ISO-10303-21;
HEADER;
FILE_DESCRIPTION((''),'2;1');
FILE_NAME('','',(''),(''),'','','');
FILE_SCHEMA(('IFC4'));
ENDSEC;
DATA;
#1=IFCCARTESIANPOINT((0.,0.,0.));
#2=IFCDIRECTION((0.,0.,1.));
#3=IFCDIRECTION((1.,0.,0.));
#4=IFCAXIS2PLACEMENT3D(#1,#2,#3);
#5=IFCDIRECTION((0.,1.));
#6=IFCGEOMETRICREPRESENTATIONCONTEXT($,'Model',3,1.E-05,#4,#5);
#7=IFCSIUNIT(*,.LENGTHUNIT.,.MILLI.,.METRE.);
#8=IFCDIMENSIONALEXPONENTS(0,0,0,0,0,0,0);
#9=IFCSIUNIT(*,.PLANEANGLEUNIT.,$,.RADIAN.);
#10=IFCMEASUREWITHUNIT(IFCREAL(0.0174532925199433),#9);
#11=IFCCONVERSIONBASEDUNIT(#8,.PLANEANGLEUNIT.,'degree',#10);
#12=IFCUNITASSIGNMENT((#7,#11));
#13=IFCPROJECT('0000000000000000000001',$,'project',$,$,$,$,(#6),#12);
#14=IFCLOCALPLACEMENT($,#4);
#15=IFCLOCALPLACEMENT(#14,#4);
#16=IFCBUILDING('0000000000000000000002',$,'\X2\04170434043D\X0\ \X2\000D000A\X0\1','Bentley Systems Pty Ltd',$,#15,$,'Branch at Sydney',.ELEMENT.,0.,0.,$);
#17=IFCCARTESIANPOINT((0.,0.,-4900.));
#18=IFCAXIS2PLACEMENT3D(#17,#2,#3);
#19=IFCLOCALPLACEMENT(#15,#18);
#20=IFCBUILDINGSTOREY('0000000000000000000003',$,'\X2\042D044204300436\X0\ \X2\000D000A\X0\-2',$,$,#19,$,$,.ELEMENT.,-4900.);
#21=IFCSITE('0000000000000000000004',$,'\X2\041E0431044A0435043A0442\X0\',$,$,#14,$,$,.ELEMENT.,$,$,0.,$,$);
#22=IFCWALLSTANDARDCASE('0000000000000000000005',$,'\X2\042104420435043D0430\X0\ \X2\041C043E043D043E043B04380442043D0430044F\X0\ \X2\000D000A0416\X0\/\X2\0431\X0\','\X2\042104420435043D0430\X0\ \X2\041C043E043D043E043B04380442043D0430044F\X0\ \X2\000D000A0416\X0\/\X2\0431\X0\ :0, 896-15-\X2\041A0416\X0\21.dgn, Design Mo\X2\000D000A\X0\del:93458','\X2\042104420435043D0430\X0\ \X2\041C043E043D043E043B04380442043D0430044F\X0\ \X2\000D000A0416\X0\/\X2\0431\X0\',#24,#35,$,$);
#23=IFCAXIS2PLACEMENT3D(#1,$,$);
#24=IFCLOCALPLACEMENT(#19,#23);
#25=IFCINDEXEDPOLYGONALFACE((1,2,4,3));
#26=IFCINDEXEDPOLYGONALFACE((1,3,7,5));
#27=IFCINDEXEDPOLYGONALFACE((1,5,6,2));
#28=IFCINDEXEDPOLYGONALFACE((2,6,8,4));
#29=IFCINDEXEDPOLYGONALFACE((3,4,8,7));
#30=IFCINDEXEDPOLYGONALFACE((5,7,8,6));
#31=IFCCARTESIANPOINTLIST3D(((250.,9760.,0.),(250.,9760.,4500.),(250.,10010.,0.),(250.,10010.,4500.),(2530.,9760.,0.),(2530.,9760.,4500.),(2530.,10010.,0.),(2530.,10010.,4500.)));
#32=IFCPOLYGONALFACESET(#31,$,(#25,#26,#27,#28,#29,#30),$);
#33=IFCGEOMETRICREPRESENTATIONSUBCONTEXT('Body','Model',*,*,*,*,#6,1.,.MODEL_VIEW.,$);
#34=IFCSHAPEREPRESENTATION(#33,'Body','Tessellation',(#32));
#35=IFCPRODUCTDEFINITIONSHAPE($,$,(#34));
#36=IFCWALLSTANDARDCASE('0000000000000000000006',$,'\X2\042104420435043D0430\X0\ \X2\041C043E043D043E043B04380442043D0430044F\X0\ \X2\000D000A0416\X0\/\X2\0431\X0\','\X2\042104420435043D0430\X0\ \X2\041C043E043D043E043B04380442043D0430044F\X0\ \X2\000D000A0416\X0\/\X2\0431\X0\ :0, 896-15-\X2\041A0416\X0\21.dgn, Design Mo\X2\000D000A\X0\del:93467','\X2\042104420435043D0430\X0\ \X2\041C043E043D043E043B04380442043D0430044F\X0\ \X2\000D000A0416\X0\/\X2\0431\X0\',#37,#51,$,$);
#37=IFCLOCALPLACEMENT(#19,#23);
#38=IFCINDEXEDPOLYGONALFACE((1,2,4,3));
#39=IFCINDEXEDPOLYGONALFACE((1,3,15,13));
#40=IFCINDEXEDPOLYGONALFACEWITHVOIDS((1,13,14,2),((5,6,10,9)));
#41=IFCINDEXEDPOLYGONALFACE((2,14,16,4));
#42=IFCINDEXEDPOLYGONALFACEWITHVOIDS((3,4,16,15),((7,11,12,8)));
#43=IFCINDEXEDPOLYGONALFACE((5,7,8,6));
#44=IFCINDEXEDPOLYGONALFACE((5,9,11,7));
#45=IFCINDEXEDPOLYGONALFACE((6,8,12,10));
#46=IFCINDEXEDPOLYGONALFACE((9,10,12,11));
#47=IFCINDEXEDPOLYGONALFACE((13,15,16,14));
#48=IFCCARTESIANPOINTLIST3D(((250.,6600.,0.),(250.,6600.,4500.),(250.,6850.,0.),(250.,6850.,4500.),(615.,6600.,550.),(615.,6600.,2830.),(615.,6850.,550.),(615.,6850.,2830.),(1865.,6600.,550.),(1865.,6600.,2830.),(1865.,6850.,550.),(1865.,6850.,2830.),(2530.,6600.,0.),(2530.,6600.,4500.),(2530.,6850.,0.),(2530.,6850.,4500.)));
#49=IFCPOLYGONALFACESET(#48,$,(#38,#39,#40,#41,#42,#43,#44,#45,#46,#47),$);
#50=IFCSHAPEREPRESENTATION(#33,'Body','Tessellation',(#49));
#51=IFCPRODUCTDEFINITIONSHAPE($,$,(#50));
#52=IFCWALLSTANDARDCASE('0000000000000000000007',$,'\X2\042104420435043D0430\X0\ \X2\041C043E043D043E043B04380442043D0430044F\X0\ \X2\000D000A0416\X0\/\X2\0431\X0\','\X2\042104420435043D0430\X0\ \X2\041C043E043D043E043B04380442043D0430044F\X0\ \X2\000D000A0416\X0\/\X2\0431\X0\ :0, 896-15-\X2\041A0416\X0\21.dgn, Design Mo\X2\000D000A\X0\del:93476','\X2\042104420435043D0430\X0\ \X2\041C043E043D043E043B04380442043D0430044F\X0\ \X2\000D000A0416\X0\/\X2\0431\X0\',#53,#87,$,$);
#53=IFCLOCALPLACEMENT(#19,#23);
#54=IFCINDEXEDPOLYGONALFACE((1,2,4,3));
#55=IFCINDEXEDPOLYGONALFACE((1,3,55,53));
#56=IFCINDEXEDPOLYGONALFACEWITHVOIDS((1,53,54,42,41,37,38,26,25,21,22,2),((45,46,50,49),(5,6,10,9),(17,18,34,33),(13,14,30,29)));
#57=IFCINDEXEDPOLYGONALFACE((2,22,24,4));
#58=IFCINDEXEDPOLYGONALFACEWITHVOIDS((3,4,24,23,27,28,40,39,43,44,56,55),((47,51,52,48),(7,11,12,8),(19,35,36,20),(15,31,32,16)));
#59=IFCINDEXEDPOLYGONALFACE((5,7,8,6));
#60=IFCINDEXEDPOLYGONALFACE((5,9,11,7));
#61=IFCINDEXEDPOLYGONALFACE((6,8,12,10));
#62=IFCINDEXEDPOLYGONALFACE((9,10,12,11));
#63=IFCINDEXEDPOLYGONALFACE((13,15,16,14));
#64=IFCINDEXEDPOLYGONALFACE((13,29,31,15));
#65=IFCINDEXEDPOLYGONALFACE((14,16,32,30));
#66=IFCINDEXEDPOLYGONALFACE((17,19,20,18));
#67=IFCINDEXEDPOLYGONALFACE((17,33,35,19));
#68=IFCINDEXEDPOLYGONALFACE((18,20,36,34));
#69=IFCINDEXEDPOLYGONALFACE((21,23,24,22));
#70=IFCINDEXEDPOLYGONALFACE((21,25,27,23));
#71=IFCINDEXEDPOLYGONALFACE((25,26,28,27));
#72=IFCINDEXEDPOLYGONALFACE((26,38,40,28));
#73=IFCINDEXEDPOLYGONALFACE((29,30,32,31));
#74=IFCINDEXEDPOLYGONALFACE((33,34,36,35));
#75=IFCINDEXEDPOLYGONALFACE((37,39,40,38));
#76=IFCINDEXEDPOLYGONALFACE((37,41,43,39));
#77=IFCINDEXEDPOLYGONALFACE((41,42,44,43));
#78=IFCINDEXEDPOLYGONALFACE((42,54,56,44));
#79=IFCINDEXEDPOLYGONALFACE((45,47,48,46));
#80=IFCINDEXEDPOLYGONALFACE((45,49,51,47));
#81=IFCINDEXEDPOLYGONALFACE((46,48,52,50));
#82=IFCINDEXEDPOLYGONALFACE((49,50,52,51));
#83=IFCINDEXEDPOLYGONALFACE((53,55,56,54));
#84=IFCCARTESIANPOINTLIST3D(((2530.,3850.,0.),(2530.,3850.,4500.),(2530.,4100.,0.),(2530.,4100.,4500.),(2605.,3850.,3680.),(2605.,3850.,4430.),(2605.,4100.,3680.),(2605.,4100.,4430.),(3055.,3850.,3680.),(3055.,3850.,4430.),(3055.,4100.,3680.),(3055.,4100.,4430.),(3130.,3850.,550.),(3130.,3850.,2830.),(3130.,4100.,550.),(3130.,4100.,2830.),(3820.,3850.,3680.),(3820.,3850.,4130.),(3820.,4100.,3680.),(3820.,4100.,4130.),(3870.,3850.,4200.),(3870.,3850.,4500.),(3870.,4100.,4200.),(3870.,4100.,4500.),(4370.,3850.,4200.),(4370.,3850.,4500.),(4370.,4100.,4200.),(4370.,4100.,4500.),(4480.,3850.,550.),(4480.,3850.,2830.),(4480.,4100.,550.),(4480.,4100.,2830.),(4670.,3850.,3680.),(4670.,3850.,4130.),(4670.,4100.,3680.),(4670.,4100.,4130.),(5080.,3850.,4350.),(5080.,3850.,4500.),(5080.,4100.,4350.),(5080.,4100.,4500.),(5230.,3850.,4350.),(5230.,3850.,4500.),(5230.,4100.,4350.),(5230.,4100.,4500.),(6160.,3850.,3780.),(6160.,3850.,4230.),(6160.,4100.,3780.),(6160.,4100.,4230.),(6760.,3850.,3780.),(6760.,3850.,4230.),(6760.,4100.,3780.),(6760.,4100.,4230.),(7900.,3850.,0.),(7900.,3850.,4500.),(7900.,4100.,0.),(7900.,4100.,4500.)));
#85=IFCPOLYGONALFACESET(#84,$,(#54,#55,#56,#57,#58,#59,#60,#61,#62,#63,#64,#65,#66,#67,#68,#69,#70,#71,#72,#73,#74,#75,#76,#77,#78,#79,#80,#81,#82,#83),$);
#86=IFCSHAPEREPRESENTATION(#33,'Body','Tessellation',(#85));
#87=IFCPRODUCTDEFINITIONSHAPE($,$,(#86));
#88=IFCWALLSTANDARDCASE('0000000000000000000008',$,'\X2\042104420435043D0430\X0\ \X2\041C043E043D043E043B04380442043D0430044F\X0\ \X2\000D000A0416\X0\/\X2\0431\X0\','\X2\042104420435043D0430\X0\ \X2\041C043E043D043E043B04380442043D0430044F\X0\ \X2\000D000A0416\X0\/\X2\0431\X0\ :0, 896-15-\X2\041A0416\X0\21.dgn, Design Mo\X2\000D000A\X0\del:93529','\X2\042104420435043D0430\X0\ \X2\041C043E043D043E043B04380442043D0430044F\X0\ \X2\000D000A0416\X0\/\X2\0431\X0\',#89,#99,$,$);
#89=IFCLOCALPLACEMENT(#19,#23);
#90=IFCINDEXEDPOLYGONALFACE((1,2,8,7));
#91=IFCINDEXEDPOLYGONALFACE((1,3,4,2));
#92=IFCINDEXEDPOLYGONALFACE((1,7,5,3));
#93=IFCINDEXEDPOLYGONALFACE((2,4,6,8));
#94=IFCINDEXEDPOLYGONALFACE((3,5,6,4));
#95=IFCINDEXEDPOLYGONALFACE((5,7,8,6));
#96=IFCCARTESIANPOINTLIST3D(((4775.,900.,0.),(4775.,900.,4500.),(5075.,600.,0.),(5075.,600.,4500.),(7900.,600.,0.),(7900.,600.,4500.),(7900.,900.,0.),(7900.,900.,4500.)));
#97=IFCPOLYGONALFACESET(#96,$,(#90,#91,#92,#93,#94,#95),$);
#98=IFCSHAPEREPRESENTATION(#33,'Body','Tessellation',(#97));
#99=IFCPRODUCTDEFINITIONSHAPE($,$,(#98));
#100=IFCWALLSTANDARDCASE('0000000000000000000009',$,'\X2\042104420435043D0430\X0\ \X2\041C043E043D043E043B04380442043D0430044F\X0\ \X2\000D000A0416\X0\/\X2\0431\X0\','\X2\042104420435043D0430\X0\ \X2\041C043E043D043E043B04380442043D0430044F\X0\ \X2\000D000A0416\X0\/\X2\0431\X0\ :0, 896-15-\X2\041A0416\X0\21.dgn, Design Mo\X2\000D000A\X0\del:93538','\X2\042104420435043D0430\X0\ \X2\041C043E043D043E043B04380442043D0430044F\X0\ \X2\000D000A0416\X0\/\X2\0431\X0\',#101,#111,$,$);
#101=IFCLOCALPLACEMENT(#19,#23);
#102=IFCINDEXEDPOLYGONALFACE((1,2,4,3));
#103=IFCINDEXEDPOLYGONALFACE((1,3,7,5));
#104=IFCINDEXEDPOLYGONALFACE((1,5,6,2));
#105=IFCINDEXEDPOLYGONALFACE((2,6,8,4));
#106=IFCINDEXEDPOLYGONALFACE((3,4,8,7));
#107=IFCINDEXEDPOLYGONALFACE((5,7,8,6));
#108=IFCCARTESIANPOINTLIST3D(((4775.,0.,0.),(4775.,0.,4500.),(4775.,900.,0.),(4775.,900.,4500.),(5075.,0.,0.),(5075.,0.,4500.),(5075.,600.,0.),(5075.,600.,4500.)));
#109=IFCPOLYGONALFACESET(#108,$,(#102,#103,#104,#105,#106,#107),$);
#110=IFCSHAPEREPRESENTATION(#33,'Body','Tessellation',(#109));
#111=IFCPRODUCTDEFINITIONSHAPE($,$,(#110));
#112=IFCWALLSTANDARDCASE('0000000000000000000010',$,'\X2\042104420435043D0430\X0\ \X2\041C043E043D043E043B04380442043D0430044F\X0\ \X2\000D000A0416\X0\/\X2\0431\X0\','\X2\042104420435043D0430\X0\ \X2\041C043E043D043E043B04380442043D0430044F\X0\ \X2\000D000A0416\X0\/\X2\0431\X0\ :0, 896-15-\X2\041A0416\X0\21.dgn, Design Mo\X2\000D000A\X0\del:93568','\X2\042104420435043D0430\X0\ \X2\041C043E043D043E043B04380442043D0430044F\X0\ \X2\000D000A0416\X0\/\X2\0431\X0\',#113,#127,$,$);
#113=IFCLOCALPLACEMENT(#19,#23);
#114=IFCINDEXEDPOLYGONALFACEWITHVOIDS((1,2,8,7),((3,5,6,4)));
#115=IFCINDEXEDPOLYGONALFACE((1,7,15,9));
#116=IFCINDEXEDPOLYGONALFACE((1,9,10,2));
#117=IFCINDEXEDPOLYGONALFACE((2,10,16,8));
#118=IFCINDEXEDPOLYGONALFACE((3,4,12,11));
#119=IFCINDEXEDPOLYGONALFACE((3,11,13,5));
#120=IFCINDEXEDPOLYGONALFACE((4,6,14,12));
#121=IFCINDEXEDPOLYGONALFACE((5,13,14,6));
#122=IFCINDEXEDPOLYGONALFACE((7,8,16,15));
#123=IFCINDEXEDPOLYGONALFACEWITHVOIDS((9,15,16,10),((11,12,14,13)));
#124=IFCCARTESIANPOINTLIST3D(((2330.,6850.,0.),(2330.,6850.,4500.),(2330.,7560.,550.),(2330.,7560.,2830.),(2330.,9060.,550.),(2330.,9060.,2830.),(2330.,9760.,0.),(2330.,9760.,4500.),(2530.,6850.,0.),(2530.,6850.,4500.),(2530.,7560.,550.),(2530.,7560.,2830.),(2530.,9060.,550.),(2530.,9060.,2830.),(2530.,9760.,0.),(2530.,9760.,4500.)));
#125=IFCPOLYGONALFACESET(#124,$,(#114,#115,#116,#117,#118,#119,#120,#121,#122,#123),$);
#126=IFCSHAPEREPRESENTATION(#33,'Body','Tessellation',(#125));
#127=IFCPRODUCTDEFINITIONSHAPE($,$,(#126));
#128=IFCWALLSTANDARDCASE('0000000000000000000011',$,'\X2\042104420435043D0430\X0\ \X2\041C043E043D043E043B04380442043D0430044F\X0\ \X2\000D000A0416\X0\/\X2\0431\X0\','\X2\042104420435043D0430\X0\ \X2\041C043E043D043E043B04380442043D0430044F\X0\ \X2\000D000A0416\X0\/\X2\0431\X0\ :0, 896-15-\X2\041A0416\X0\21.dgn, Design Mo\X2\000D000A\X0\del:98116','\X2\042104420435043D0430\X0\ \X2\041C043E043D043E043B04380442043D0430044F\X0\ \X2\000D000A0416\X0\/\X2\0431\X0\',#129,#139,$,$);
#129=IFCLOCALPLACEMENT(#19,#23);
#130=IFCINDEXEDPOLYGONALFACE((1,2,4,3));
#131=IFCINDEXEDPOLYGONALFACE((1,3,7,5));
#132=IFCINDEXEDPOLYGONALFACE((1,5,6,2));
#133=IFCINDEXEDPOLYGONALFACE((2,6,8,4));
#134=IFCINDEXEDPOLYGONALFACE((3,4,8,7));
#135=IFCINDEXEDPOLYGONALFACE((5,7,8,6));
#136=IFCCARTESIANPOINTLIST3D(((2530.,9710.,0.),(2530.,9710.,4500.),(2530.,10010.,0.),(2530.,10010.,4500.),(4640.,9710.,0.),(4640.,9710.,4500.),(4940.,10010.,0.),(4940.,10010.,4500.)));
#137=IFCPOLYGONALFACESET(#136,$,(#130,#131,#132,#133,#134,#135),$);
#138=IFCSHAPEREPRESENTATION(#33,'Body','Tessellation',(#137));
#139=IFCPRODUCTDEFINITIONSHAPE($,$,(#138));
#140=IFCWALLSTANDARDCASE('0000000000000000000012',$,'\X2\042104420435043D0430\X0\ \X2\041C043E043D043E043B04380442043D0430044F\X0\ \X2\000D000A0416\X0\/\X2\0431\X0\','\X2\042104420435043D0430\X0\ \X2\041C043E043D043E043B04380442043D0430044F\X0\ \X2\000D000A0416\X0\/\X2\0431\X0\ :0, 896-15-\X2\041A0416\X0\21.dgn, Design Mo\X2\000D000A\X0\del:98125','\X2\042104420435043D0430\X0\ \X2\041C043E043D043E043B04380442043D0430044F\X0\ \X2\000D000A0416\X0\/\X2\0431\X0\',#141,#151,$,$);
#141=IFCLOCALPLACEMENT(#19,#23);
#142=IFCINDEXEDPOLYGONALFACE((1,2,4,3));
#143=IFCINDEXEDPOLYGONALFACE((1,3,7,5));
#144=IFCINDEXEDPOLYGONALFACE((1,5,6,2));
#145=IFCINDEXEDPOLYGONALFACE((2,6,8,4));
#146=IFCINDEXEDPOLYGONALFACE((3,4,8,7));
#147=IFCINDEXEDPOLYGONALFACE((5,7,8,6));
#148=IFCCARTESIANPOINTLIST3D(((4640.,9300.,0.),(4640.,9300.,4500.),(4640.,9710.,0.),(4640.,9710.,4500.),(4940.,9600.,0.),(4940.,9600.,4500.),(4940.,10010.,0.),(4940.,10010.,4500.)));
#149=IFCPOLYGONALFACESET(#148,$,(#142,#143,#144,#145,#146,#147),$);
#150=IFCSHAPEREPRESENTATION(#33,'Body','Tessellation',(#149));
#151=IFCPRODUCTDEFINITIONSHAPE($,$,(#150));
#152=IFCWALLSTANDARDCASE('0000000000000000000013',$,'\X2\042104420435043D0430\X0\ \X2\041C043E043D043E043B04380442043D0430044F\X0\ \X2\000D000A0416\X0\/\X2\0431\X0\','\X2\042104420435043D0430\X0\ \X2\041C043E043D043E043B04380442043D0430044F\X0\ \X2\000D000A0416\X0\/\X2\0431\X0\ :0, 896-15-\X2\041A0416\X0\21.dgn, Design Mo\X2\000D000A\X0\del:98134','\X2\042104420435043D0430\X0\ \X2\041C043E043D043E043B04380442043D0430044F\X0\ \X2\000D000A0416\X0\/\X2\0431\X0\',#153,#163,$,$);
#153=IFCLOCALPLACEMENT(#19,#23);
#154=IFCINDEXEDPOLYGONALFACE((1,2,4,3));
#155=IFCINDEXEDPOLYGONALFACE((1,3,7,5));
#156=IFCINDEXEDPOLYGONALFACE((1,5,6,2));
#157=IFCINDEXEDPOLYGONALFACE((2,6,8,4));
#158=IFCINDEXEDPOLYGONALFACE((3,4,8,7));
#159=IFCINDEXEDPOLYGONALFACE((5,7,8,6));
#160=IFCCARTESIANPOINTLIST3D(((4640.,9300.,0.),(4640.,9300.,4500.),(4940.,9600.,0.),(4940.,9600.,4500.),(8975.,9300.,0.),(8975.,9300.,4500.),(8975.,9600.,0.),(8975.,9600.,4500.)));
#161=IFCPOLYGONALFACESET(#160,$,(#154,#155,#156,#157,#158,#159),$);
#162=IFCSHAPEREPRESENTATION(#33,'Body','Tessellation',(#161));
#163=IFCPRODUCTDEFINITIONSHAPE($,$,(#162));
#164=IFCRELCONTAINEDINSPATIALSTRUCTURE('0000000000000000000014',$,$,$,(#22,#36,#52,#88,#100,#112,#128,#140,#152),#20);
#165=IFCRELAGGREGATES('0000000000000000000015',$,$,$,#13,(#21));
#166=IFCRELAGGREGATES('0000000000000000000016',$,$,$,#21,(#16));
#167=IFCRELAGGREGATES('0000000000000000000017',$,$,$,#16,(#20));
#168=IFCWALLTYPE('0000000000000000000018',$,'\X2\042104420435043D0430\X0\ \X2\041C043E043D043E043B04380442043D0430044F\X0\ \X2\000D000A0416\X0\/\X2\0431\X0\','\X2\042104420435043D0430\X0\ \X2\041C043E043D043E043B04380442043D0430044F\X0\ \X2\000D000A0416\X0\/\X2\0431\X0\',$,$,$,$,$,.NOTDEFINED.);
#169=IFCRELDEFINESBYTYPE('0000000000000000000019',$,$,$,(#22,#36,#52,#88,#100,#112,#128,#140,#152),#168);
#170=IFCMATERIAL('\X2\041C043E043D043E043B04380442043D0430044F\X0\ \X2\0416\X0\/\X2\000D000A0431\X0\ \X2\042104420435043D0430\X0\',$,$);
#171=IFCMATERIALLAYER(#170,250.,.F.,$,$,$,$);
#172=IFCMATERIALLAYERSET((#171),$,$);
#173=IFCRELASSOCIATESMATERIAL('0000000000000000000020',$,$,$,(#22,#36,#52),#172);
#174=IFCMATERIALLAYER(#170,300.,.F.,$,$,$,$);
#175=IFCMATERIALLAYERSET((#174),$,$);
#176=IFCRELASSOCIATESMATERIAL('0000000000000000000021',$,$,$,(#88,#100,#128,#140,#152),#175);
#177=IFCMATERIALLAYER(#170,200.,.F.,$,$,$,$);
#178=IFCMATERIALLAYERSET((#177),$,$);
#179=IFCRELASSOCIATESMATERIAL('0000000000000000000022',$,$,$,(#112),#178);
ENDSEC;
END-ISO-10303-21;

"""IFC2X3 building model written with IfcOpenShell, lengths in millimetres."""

from ifc_helpers import new_model, entity, si_unit, converted_unit, direction, frame, frame_2d, origin_with_axes, place, context, subcontext, project, spatial, polyline, rectangle, outline, extrude, material, layer, layer_set, layer_usage, type_object, element, save


model = new_model("IFC2X3")

# Units and contexts
model_context = context("Model", 3, precision=1e-05, world=origin_with_axes(), true_north=direction((0.0, 1.0)))
body_context = subcontext(model_context, "Body", "Model", "MODEL_VIEW", scale=1.0)
ifc_project = project(units=[si_unit("LENGTHUNIT", "METRE", prefix="MILLI"), converted_unit("PLANEANGLEUNIT", "degree", entity("IfcReal", 0.0174532925199433), si_unit("PLANEANGLEUNIT", "RADIAN"), dimensions=[0, 0, 0, 0, 0, 0, 0])], contexts=[model_context])

# Site, building, storey
site_placement = place(None, origin_with_axes())
site = spatial("IfcSite", under=ifc_project, at=site_placement, Name="Объект", CompositionType="ELEMENT", RefElevation=0.0)
building_placement = place(site_placement, origin_with_axes())
building = spatial("IfcBuilding", under=site, at=building_placement, Name="Здн \r\n1", Description="Bentley Systems Pty Ltd", LongName="Branch at Sydney", CompositionType="ELEMENT", ElevationOfRefHeight=0.0, ElevationOfTerrain=0.0)
storey_placement = place(building_placement, frame((0.0, 0.0, -4900.0), z_axis=(0.0, 0.0, 1.0), x_axis=(1.0, 0.0, 0.0)))
storey = spatial("IfcBuildingStorey", under=building, at=storey_placement, Name="Этаж \r\n-2", CompositionType="ELEMENT", Elevation=-4900.0)

# Wall
ifc_material = material(Name="Монолитная Ж/\r\nб Стена")
ifc_layer_1 = layer(ifc_material, 250.0, ventilated=False)
ifc_layer_set_1 = layer_set([ifc_layer_1])
ifc_layer_usage_1 = layer_usage(ifc_layer_set_1, "AXIS2", "POSITIVE", 0.0)
wall_type = type_object("IfcWallType", Name="Стена Монолитная \r\nЖ/б", Description="Стена Монолитная \r\nЖ/б", PredefinedType="NOTDEFINED")
wall_1_placement = place(storey_placement, frame((2530.0, 10010.0, 0.0), z_axis=(0.0, 0.0, 1.0), x_axis=(-1.0, 0.0, 0.0)))
element("IfcWallStandardCase", 1, at=wall_1_placement, inside=storey, type_object=wall_type, material=ifc_layer_usage_1, Name="Стена Монолитная \r\nЖ/б", Description="Стена Монолитная \r\nЖ/б :0, 896-15-КЖ21.dgn, Design Mo\r\ndel:93458", ObjectType="Стена Монолитная \r\nЖ/б", context=body_context, shape_type="SweptSolid", body=[
    extrude(rectangle(XDim=2280.0, YDim=250.0, at=frame_2d((1140.0, 125.0), x_axis=(1.0, 0.0))), origin_with_axes(), (0.0, 0.0, 1.0), 4500.0),
])

# Wall, opening
wall_2_placement = place(storey_placement, frame((250.0, 6600.0, 0.0), z_axis=(0.0, 0.0, 1.0), x_axis=(1.0, 0.0, 0.0)))
wall_2 = element("IfcWallStandardCase", 2, at=wall_2_placement, inside=storey, type_object=wall_type, material=ifc_layer_usage_1, Name="Стена Монолитная \r\nЖ/б", Description="Стена Монолитная \r\nЖ/б :0, 896-15-КЖ21.dgn, Design Mo\r\ndel:93467", ObjectType="Стена Монолитная \r\nЖ/б", context=body_context, shape_type="SweptSolid", body=[
    extrude(rectangle(XDim=2280.0, YDim=250.0, at=frame_2d((1140.0, 125.0), x_axis=(1.0, 0.0))), origin_with_axes(), (0.0, 0.0, 1.0), 4500.0),
])
opening_1_placement = place(wall_2_placement, frame((365.0, 0.0, 550.0), z_axis=(0.0, 0.0, 1.0), x_axis=(1.0, 0.0, 0.0)))
element("IfcOpeningElement", 3, at=opening_1_placement, cuts=wall_2, ObjectType="Opening", context=body_context, shape_type="SweptSolid", body=[
    extrude(rectangle(XDim=2280.0, YDim=1250.0, at=frame_2d((-625.0, 1140.0), x_axis=(0.0, -1.0))), frame((0.0, 0.0, 0.0), z_axis=(0.0, 1.0, 0.0), x_axis=(-1.0, 0.0, 0.0)), (0.0, 0.0, 1.0), 250.0),
])

# Wall, openings
wall_3_placement = place(storey_placement, frame((2530.0, 3850.0, 0.0), z_axis=(0.0, 0.0, 1.0), x_axis=(1.0, 0.0, 0.0)))
wall_3 = element("IfcWallStandardCase", 4, at=wall_3_placement, inside=storey, type_object=wall_type, material=ifc_layer_usage_1, Name="Стена Монолитная \r\nЖ/б", Description="Стена Монолитная \r\nЖ/б :0, 896-15-КЖ21.dgn, Design Mo\r\ndel:93476", ObjectType="Стена Монолитная \r\nЖ/б", context=body_context, shape_type="SweptSolid", body=[
    extrude(rectangle(XDim=5370.0, YDim=250.0, at=frame_2d((2685.0, 125.0), x_axis=(1.0, 0.0))), origin_with_axes(), (0.0, 0.0, 1.0), 4500.0),
])
opening_2_placement = place(wall_3_placement, frame((600.0, 0.0, 550.0), z_axis=(0.0, 0.0, 1.0), x_axis=(1.0, 0.0, 0.0)))
element("IfcOpeningElement", 5, at=opening_2_placement, cuts=wall_3, ObjectType="Opening", context=body_context, shape_type="SweptSolid", body=[
    extrude(rectangle(XDim=2280.0, YDim=1350.0, at=frame_2d((-675.0, 1140.0), x_axis=(0.0, -1.0))), frame((0.0, 0.0, 0.0), z_axis=(0.0, 1.0, 0.0), x_axis=(-1.0, 0.0, 0.0)), (0.0, 0.0, 1.0), 250.0),
])
opening_3_placement = place(wall_3_placement, frame((75.0, 0.0, 3680.0), z_axis=(0.0, 0.0, 1.0), x_axis=(1.0, 0.0, 0.0)))
element("IfcOpeningElement", 6, at=opening_3_placement, cuts=wall_3, ObjectType="Opening", context=body_context, shape_type="SweptSolid", body=[
    extrude(rectangle(XDim=750.0, YDim=450.0, at=frame_2d((-225.0, 375.0), x_axis=(0.0, -1.0))), frame((0.0, 0.0, 0.0), z_axis=(0.0, 1.0, 0.0), x_axis=(-1.0, 0.0, 0.0)), (0.0, 0.0, 1.0), 250.0),
])
opening_4_placement = place(wall_3_placement, frame((1290.0, 0.0, 3680.0), z_axis=(0.0, 0.0, 1.0), x_axis=(1.0, 0.0, 0.0)))
element("IfcOpeningElement", 7, at=opening_4_placement, cuts=wall_3, ObjectType="Opening", context=body_context, shape_type="SweptSolid", body=[
    extrude(rectangle(XDim=450.0, YDim=850.0, at=frame_2d((-425.0, 225.0), x_axis=(0.0, -1.0))), frame((0.0, 0.0, 0.0), z_axis=(0.0, 1.0, 0.0), x_axis=(-1.0, 0.0, 0.0)), (0.0, 0.0, 1.0), 250.0),
])
opening_5_placement = place(wall_3_placement, frame((1340.0, 0.0, 4200.0), z_axis=(0.0, 0.0, 1.0), x_axis=(1.0, 0.0, 0.0)))
element("IfcOpeningElement", 8, at=opening_5_placement, cuts=wall_3, ObjectType="Opening", context=body_context, shape_type="SweptSolid", body=[
    extrude(rectangle(XDim=300.0, YDim=500.0, at=frame_2d((-250.0, 150.0), x_axis=(0.0, -1.0))), frame((0.0, 0.0, 0.0), z_axis=(0.0, 1.0, 0.0), x_axis=(-1.0, 0.0, 0.0)), (0.0, 0.0, 1.0), 250.0),
])
opening_6_placement = place(wall_3_placement, frame((2550.0, 0.0, 4350.0), z_axis=(0.0, 0.0, 1.0), x_axis=(1.0, 0.0, 0.0)))
element("IfcOpeningElement", 9, at=opening_6_placement, cuts=wall_3, ObjectType="Opening", context=body_context, shape_type="SweptSolid", body=[
    extrude(rectangle(XDim=150.0, YDim=150.0, at=frame_2d((-75.0, 75.0), x_axis=(0.0, -1.0))), frame((0.0, 0.0, 0.0), z_axis=(0.0, 1.0, 0.0), x_axis=(-1.0, 0.0, 0.0)), (0.0, 0.0, 1.0), 250.0),
])
opening_7_placement = place(wall_3_placement, frame((3630.0, 0.0, 3780.0), z_axis=(0.0, 0.0, 1.0), x_axis=(1.0, 0.0, 0.0)))
element("IfcOpeningElement", 10, at=opening_7_placement, cuts=wall_3, ObjectType="Opening", context=body_context, shape_type="SweptSolid", body=[
    extrude(rectangle(XDim=450.0, YDim=600.0, at=frame_2d((-300.0, 225.0), x_axis=(0.0, -1.0))), frame((0.0, 0.0, 0.0), z_axis=(0.0, 1.0, 0.0), x_axis=(-1.0, 0.0, 0.0)), (0.0, 0.0, 1.0), 250.0),
])

# Walls
ifc_layer_2 = layer(ifc_material, 300.0, ventilated=False)
ifc_layer_set_2 = layer_set([ifc_layer_2])
ifc_layer_usage_2 = layer_usage(ifc_layer_set_2, "AXIS2", "POSITIVE", 0.0)
wall_4_placement = place(storey_placement, frame((7900.0, 900.0, 0.0), z_axis=(0.0, 0.0, 1.0), x_axis=(-1.0, 0.0, 0.0)))
element("IfcWallStandardCase", 11, at=wall_4_placement, inside=storey, type_object=wall_type, material=ifc_layer_usage_2, Name="Стена Монолитная \r\nЖ/б", Description="Стена Монолитная \r\nЖ/б :0, 896-15-КЖ21.dgn, Design Mo\r\ndel:93529", ObjectType="Стена Монолитная \r\nЖ/б", context=body_context, shape_type="SweptSolid", body=[
    extrude(outline(polyline([(2825.0, 300.0), (0.0, 300.0), (0.0, 0.0), (3125.0, 0.0), (2825.0, 300.0)])), origin_with_axes(), (0.0, 0.0, 1.0), 4500.0),
])
wall_5_placement = place(storey_placement, frame((4775.0, 900.0, 0.0), z_axis=(0.0, 0.0, 1.0), x_axis=(0.0, -1.0, 0.0)))
element("IfcWallStandardCase", 12, at=wall_5_placement, inside=storey, type_object=wall_type, material=ifc_layer_usage_2, Name="Стена Монолитная \r\nЖ/б", Description="Стена Монолитная \r\nЖ/б :0, 896-15-КЖ21.dgn, Design Mo\r\ndel:93538", ObjectType="Стена Монолитная \r\nЖ/б", context=body_context, shape_type="SweptSolid", body=[
    extrude(outline(polyline([(900.0, 300.0), (300.0, 300.0), (0.0, 0.0), (900.0, 0.0), (900.0, 300.0)])), origin_with_axes(), (0.0, 0.0, 1.0), 4500.0),
])

# Wall, opening
ifc_layer_3 = layer(ifc_material, 200.0, ventilated=False)
ifc_layer_set_3 = layer_set([ifc_layer_3])
ifc_layer_usage_3 = layer_usage(ifc_layer_set_3, "AXIS2", "POSITIVE", 0.0)
wall_6_placement = place(storey_placement, frame((2330.0, 9760.0, 0.0), z_axis=(0.0, 0.0, 1.0), x_axis=(0.0, -1.0, 0.0)))
wall_6 = element("IfcWallStandardCase", 13, at=wall_6_placement, inside=storey, type_object=wall_type, material=ifc_layer_usage_3, Name="Стена Монолитная \r\nЖ/б", Description="Стена Монолитная \r\nЖ/б :0, 896-15-КЖ21.dgn, Design Mo\r\ndel:93568", ObjectType="Стена Монолитная \r\nЖ/б", context=body_context, shape_type="SweptSolid", body=[
    extrude(rectangle(XDim=2910.0, YDim=200.0, at=frame_2d((1455.0, 100.0), x_axis=(-1.0, 0.0))), origin_with_axes(), (0.0, 0.0, 1.0), 4500.0),
])
opening_8_placement = place(wall_6_placement, frame((700.0, 0.0, 550.0), z_axis=(0.0, 0.0, 1.0), x_axis=(1.0, 0.0, 0.0)))
element("IfcOpeningElement", 14, at=opening_8_placement, cuts=wall_6, ObjectType="Opening", context=body_context, shape_type="SweptSolid", body=[
    extrude(rectangle(XDim=2280.0, YDim=1500.0, at=frame_2d((-750.0, 1140.0), x_axis=(0.0, -1.0))), frame((0.0, 0.0, 0.0), z_axis=(0.0, 1.0, 0.0), x_axis=(-1.0, 0.0, 0.0)), (0.0, 0.0, 1.0), 200.0),
])

# Walls
wall_7_placement = place(storey_placement, frame((2530.0, 10010.0, 0.0), z_axis=(0.0, 0.0, 1.0), x_axis=(1.0, 0.0, 0.0)))
element("IfcWallStandardCase", 15, at=wall_7_placement, inside=storey, type_object=wall_type, material=ifc_layer_usage_2, Name="Стена Монолитная \r\nЖ/б", Description="Стена Монолитная \r\nЖ/б :0, 896-15-КЖ21.dgn, Design Mo\r\ndel:98116", ObjectType="Стена Монолитная \r\nЖ/б", context=body_context, shape_type="SweptSolid", body=[
    extrude(outline(polyline([(2410.0, 0.0), (0.0, 0.0), (0.0, -300.0), (2110.0, -300.0), (2410.0, 0.0)])), origin_with_axes(), (0.0, 0.0, 1.0), 4500.0),
])
wall_8_placement = place(storey_placement, frame((4940.0, 10010.0, 0.0), z_axis=(0.0, 0.0, 1.0), x_axis=(0.0, -1.0, 0.0)))
element("IfcWallStandardCase", 16, at=wall_8_placement, inside=storey, type_object=wall_type, material=ifc_layer_usage_2, Name="Стена Монолитная \r\nЖ/б", Description="Стена Монолитная \r\nЖ/б :0, 896-15-КЖ21.dgn, Design Mo\r\ndel:98125", ObjectType="Стена Монолитная \r\nЖ/б", context=body_context, shape_type="SweptSolid", body=[
    extrude(outline(polyline([(410.0, 0.0), (0.0, 0.0), (300.0, -300.0), (710.0, -300.0), (410.0, 0.0)])), origin_with_axes(), (0.0, 0.0, 1.0), 4500.0),
])
wall_9_placement = place(storey_placement, frame((4940.0, 9600.0, 0.0), z_axis=(0.0, 0.0, 1.0), x_axis=(1.0, 0.0, 0.0)))
element("IfcWallStandardCase", 17, at=wall_9_placement, inside=storey, type_object=wall_type, material=ifc_layer_usage_2, Name="Стена Монолитная \r\nЖ/б", Description="Стена Монолитная \r\nЖ/б :0, 896-15-КЖ21.dgn, Design Mo\r\ndel:98134", ObjectType="Стена Монолитная \r\nЖ/б", context=body_context, shape_type="SweptSolid", body=[
    extrude(outline(polyline([(0.0, 0.0), (-300.0, -300.0), (4035.0, -300.0), (4035.0, 0.0), (0.0, 0.0)])), origin_with_axes(), (0.0, 0.0, 1.0), 4500.0),
])

save(model, "model.ifc")
